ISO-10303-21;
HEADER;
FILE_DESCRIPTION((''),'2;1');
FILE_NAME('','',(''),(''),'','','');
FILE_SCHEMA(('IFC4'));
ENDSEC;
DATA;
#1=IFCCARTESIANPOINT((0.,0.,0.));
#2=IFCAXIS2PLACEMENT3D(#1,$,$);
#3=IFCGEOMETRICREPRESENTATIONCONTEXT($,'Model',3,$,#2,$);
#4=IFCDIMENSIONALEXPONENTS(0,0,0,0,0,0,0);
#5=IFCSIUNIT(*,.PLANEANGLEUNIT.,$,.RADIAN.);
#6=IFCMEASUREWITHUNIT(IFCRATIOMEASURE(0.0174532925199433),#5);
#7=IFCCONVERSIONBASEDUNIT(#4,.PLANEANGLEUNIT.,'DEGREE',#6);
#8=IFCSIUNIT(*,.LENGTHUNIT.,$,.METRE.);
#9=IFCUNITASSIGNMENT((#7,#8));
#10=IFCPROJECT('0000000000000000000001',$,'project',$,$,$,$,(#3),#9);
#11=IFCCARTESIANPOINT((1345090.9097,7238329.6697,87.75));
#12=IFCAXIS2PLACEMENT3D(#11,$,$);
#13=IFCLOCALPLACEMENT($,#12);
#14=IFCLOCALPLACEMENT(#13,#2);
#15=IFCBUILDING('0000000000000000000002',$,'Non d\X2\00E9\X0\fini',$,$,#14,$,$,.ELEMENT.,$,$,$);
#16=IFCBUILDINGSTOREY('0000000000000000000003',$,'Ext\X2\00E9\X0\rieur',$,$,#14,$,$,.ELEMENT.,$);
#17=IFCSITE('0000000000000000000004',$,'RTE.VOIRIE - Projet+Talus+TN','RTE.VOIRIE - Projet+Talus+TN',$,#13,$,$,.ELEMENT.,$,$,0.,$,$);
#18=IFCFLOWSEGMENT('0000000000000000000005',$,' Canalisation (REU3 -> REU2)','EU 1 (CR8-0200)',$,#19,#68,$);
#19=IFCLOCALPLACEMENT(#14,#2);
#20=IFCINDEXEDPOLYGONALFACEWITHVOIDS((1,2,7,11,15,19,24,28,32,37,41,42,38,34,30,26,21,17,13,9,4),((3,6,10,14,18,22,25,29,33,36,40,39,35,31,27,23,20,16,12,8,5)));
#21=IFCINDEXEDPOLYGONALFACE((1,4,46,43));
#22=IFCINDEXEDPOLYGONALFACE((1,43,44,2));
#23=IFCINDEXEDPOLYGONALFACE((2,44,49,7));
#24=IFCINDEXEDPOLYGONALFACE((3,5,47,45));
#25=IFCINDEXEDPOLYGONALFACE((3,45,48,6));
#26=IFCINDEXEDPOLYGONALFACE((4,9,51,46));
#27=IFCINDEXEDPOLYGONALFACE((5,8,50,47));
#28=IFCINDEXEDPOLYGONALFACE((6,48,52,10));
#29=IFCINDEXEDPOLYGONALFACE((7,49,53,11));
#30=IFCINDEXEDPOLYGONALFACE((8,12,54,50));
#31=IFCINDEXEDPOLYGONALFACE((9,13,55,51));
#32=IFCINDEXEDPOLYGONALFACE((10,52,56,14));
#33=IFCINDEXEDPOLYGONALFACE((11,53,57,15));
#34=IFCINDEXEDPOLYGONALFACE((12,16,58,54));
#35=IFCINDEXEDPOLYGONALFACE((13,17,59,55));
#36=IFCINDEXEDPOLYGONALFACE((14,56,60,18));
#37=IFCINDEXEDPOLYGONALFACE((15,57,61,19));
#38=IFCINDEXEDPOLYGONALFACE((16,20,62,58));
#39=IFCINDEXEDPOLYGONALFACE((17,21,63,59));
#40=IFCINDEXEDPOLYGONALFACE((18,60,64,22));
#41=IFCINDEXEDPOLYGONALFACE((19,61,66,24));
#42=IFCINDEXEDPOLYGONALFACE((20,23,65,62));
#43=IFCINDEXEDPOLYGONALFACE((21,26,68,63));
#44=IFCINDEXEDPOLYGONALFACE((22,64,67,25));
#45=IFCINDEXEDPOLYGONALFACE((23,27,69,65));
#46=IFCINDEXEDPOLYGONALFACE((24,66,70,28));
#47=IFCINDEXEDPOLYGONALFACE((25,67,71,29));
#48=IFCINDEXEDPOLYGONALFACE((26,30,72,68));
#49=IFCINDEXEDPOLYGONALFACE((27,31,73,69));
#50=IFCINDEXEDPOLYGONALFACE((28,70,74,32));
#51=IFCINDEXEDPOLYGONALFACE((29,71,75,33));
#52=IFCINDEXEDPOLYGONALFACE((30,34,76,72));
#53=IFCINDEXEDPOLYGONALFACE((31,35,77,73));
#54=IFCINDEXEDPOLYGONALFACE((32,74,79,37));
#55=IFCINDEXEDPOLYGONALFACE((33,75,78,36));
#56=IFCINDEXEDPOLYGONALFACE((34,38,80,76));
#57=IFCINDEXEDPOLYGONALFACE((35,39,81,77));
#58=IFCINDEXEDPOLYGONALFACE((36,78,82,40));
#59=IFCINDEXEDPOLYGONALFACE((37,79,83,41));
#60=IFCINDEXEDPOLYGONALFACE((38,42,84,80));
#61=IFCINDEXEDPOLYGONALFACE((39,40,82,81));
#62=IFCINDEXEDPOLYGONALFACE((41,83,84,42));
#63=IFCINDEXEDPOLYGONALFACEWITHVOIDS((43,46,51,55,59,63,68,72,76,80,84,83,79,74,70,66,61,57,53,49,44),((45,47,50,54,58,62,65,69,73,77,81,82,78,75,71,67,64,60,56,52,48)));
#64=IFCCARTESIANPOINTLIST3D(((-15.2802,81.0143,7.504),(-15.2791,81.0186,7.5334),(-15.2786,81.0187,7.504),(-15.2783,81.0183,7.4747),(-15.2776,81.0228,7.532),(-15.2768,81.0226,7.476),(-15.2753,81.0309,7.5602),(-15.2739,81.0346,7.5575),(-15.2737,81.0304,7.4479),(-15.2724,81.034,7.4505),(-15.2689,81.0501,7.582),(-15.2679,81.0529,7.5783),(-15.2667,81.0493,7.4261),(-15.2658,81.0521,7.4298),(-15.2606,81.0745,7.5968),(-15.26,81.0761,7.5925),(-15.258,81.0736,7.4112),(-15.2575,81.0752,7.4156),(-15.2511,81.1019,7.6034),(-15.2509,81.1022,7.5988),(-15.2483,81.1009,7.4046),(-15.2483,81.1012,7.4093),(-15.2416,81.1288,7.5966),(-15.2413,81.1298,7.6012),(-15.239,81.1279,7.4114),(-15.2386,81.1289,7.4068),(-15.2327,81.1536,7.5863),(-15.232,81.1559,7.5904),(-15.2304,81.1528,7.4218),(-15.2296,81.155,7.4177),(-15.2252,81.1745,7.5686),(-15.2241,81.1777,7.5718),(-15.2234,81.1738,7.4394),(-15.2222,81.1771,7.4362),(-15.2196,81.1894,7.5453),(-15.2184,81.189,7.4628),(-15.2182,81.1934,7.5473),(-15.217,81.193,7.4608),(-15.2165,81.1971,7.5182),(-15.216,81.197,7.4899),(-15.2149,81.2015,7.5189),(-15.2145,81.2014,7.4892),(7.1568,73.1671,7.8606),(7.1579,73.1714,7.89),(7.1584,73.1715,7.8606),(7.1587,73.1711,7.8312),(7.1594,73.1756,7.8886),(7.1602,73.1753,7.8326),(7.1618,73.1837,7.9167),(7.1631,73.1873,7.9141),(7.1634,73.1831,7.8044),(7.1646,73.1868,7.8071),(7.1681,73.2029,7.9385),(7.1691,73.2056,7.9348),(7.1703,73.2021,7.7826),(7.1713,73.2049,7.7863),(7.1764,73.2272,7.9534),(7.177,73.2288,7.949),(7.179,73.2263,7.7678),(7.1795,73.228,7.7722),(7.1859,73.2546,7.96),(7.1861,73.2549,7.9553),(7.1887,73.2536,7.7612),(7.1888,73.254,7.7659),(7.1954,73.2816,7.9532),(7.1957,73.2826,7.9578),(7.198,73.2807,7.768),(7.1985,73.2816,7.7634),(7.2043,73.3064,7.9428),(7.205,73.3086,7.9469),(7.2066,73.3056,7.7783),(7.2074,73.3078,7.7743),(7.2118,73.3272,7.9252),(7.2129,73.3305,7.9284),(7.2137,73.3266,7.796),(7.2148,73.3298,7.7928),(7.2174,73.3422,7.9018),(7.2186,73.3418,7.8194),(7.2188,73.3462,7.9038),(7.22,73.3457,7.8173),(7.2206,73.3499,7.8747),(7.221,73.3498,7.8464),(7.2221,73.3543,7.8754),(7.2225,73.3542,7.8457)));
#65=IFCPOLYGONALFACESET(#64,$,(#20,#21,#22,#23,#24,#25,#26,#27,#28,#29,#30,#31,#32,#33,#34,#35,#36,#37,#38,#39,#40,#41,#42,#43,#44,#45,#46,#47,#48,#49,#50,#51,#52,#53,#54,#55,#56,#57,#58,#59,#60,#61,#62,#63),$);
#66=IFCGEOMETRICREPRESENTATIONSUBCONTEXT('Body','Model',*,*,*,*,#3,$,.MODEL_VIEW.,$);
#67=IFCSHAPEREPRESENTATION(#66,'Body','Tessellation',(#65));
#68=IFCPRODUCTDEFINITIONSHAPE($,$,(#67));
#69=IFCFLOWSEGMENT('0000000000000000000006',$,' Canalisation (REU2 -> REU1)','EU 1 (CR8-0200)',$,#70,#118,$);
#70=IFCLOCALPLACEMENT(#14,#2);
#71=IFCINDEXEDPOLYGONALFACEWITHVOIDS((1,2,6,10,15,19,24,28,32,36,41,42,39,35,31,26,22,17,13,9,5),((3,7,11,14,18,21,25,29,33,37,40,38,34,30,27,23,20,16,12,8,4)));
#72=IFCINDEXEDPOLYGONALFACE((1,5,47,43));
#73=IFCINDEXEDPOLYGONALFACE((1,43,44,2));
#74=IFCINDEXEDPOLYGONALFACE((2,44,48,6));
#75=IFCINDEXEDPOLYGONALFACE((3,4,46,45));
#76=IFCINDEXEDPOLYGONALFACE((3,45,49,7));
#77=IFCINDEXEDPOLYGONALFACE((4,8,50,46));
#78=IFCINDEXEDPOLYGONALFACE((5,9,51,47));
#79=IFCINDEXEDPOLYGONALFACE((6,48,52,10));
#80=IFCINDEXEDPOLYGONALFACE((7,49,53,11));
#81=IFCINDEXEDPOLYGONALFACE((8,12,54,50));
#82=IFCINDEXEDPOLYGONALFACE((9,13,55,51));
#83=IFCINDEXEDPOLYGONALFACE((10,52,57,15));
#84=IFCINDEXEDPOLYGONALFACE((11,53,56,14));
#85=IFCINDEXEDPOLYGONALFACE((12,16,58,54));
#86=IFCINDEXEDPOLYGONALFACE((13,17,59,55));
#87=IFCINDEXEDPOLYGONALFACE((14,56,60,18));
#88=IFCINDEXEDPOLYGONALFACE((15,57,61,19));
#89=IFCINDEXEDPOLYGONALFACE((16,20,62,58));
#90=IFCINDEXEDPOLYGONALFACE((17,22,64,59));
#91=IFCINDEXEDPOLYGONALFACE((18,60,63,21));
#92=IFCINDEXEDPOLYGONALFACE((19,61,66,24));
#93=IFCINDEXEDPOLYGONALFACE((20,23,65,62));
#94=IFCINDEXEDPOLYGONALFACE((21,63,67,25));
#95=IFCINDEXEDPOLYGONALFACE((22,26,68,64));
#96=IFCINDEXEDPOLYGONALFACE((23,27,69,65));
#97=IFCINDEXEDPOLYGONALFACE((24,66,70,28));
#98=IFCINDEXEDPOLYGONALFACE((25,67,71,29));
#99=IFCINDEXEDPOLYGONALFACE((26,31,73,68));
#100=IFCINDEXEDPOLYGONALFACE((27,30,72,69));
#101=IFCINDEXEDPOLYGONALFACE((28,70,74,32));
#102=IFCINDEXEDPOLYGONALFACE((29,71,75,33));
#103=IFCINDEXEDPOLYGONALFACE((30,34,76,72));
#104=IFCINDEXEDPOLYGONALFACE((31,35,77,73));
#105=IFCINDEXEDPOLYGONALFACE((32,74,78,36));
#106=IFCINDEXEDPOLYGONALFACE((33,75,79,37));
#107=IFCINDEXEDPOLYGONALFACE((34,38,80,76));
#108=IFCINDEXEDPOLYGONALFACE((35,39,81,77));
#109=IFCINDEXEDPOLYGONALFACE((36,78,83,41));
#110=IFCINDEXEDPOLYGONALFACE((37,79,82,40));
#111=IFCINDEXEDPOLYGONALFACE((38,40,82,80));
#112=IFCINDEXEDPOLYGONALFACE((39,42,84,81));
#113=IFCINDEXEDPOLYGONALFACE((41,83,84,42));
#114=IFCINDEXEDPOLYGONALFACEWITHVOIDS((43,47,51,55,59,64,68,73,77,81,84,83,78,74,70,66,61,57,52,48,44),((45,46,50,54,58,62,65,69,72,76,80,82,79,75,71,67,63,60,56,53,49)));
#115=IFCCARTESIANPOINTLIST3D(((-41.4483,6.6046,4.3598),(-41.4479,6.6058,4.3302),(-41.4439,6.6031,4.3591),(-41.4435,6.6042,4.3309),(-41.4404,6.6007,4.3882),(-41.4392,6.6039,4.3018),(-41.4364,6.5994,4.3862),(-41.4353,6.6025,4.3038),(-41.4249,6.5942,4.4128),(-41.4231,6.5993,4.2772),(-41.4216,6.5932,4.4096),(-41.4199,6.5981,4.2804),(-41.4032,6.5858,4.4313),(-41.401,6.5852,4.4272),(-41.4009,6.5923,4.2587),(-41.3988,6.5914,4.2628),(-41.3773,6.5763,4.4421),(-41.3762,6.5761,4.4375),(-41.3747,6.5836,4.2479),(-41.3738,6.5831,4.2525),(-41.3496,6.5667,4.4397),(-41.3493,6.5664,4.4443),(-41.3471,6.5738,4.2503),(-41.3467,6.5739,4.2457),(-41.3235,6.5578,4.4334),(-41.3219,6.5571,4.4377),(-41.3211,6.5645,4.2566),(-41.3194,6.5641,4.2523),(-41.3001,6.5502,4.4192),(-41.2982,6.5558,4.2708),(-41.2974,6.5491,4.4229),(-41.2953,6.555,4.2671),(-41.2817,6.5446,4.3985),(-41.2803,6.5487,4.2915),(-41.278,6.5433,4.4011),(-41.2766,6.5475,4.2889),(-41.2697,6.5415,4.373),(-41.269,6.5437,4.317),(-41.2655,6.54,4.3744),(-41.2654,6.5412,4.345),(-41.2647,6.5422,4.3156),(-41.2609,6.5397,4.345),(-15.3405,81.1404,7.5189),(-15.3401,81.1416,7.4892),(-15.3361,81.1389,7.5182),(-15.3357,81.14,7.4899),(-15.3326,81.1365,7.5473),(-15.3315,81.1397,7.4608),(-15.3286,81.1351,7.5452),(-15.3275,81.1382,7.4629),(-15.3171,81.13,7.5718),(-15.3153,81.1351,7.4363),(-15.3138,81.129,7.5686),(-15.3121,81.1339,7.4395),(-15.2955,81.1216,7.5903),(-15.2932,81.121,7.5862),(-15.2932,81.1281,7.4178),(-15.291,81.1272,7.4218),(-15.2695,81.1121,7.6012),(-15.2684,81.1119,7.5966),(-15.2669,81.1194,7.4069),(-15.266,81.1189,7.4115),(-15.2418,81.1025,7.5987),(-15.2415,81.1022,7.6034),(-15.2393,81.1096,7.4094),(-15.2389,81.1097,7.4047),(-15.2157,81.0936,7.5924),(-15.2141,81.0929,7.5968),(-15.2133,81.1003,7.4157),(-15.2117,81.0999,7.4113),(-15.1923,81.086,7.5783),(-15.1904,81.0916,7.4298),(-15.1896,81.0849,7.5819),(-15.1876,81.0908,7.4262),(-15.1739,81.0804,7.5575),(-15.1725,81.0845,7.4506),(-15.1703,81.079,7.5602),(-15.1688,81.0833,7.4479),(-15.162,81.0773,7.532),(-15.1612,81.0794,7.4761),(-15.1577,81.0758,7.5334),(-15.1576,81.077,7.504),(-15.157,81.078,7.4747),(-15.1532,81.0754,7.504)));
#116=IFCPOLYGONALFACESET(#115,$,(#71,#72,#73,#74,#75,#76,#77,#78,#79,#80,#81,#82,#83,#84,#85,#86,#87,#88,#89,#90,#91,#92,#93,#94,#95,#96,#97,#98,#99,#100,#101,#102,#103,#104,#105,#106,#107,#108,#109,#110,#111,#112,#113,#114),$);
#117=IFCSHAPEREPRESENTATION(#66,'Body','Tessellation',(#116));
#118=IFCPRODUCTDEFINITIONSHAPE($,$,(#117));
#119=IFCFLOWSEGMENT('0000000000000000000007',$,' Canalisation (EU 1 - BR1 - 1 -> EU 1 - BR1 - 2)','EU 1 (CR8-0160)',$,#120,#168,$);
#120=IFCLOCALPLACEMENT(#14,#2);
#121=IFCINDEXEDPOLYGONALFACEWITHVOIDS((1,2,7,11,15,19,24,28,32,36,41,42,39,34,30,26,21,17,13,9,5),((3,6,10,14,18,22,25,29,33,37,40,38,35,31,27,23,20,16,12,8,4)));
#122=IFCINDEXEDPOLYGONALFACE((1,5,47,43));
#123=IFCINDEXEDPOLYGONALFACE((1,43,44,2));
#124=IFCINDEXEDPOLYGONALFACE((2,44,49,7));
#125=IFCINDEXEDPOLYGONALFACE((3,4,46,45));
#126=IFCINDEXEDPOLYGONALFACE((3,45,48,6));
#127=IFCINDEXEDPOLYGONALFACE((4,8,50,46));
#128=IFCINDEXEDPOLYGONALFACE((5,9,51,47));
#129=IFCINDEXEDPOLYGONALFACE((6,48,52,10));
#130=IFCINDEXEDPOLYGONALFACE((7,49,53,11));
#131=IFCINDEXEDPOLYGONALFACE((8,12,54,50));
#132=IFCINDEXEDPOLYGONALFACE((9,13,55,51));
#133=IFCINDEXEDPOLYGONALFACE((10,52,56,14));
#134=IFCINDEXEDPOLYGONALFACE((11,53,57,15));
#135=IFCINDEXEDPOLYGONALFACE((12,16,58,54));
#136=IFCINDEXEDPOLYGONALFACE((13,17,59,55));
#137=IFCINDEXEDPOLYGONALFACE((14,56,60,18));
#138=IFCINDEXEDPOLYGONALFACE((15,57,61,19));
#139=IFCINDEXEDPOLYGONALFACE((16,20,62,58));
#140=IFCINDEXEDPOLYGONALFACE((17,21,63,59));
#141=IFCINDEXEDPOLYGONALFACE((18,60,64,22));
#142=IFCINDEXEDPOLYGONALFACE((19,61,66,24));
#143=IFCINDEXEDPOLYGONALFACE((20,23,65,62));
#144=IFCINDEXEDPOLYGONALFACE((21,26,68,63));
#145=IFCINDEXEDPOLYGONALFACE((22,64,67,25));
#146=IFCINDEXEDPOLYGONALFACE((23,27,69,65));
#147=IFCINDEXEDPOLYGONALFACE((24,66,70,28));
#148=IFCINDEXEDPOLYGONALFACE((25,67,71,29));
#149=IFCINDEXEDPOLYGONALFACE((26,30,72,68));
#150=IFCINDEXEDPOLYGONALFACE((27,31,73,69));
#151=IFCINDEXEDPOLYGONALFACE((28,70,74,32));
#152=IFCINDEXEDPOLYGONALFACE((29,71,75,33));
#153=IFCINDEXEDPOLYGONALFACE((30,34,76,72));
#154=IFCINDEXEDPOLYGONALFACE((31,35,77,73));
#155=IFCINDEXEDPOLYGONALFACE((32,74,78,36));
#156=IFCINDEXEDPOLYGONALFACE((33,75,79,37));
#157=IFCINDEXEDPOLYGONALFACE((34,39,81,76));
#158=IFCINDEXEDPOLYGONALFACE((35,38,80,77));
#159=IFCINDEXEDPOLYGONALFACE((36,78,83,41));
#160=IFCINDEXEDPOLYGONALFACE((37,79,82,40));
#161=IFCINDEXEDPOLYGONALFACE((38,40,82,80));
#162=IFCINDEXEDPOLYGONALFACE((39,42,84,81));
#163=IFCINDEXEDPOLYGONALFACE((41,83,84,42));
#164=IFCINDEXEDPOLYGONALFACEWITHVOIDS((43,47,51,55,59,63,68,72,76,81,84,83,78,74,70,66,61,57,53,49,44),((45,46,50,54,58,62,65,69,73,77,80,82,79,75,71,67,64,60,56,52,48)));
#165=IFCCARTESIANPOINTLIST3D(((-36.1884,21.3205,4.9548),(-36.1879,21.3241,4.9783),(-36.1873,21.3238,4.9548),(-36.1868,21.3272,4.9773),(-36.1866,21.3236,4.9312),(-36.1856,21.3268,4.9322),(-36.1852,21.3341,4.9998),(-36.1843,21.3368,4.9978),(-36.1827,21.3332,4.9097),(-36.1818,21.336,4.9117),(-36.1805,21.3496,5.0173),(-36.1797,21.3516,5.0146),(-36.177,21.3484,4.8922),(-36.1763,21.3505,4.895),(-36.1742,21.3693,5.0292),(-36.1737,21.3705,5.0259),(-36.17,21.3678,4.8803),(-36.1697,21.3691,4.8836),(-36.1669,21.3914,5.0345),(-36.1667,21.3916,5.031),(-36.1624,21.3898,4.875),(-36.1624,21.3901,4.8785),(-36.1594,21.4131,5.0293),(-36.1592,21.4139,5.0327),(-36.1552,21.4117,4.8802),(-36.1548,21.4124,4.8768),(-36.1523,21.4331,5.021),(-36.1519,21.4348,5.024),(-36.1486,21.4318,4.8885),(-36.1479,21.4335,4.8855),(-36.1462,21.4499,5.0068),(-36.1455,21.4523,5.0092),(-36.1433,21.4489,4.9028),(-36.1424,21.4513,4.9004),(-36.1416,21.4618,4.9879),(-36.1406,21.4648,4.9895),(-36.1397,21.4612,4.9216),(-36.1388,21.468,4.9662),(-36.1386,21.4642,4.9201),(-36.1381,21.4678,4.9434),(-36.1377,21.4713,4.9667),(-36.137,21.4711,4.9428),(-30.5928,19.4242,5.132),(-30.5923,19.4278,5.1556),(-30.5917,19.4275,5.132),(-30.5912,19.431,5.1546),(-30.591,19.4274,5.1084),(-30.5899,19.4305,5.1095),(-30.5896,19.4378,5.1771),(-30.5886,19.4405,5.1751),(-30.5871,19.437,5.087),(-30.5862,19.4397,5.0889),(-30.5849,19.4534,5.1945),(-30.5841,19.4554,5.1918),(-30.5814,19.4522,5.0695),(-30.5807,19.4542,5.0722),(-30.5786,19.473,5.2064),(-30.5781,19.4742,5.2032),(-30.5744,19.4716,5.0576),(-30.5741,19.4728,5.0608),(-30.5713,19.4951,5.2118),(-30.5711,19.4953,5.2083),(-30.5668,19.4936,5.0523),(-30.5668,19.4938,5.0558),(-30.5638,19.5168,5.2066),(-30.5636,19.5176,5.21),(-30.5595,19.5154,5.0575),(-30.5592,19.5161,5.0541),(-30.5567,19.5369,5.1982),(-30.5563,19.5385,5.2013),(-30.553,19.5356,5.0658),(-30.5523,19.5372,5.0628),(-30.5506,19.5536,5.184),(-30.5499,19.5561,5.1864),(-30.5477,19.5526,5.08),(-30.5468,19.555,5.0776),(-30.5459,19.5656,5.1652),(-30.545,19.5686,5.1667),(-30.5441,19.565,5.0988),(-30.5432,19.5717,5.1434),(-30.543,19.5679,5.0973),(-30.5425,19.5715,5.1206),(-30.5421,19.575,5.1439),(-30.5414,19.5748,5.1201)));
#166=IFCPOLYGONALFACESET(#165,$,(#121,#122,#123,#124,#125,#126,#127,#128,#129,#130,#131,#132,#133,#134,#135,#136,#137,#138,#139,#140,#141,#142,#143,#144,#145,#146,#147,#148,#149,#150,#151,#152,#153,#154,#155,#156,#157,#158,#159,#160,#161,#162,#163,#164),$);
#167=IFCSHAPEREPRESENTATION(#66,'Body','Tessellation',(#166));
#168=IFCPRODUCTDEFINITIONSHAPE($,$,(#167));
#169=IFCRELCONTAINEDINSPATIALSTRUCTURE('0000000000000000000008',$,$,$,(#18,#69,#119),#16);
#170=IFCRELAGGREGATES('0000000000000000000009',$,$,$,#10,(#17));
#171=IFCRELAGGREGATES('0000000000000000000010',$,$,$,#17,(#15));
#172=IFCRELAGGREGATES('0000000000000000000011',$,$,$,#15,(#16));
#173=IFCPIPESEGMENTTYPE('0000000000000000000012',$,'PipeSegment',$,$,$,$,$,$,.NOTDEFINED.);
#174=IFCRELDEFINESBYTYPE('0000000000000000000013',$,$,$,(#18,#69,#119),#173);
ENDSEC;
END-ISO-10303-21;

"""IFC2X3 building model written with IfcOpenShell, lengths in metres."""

from ifc_helpers import new_model, entity, si_unit, converted_unit, frame, origin, origin_2d_with_axis, place, context, subcontext, project, spatial, hollow_circle, extrude, type_object, element, save


model = new_model("IFC2X3")

# Units and contexts
model_context = context("Model", 3, world=origin())
body_context = subcontext(model_context, "Body", "Model", "MODEL_VIEW")
ifc_project = project(units=[converted_unit("PLANEANGLEUNIT", "DEGREE", entity("IfcRatioMeasure", 0.0174532925199433), si_unit("PLANEANGLEUNIT", "RADIAN"), dimensions=[0, 0, 0, 0, 0, 0, 0]), si_unit("LENGTHUNIT", "METRE")], contexts=[model_context])

# Site, building, storey
site_placement = place(None, frame((1345090.9097, 7238329.6697, 87.75)))
site = spatial("IfcSite", under=ifc_project, at=site_placement, Name="RTE.VOIRIE - Projet+Talus+TN", Description="RTE.VOIRIE - Projet+Talus+TN", CompositionType="ELEMENT", RefElevation=0.0)
placement = place(site_placement, origin())
building = spatial("IfcBuilding", under=site, at=placement, Name="Non défini", CompositionType="ELEMENT")
storey = spatial("IfcBuildingStorey", under=building, at=placement, Name="Extérieur", CompositionType="ELEMENT")

# Flow segments
pipe_segment_type_1 = type_object("IfcPipeSegmentType", Name="PipeSegment", PredefinedType="NOTDEFINED")
flow_segment_1_placement = place(placement, origin())
element("IfcFlowSegment", 1, at=flow_segment_1_placement, inside=storey, type_object=pipe_segment_type_1, Name=" Canalisation (REU3 -> REU2)", Description="EU 1 (CR8-0200)", context=body_context, shape_type="SweptSolid", body=[
    extrude(hollow_circle(Radius=0.0997, WallThickness=0.0047, at=origin_2d_with_axis()), frame((7.1898, 73.2612, 7.8606), z_axis=(-0.943827, 0.330099, -0.014998), x_axis=(-0.330099, -0.943827, 0.0)), (0.0, 0.0, 1.0), 23.7724),
])
flow_segment_2_placement = place(placement, origin())
element("IfcFlowSegment", 2, at=flow_segment_2_placement, inside=storey, type_object=pipe_segment_type_1, Name=" Canalisation (REU2 -> REU1)", Description="EU 1 (CR8-0200)", context=body_context, shape_type="SweptSolid", body=[
    extrude(hollow_circle(Radius=0.0997, WallThickness=0.0047, at=origin_2d_with_axis()), frame((-15.2473, 81.1084, 7.504), z_axis=(-0.330315, -0.943024, -0.039968), x_axis=(0.943024, -0.330315, 0.0)), (0.0, 0.0, 1.0), 79.0391),
])
flow_segment_3_placement = place(placement, origin())
element("IfcFlowSegment", 3, at=flow_segment_3_placement, inside=storey, type_object=pipe_segment_type_1, Name=" Canalisation (EU 1 - BR1 - 1 -> EU 1 - BR1 - 2)", Description="EU 1 (CR8-0160)", context=body_context, shape_type="SweptSolid", body=[
    extrude(hollow_circle(Radius=0.08, WallThickness=0.0035, at=origin_2d_with_axis()), frame((-30.5671, 19.5, 5.132), z_axis=(-0.946669, 0.320809, -0.029987), x_axis=(-0.320809, -0.946669, 0.0)), (0.0, 0.0, 1.0), 5.9108),
])

save(model, "model.ifc")
